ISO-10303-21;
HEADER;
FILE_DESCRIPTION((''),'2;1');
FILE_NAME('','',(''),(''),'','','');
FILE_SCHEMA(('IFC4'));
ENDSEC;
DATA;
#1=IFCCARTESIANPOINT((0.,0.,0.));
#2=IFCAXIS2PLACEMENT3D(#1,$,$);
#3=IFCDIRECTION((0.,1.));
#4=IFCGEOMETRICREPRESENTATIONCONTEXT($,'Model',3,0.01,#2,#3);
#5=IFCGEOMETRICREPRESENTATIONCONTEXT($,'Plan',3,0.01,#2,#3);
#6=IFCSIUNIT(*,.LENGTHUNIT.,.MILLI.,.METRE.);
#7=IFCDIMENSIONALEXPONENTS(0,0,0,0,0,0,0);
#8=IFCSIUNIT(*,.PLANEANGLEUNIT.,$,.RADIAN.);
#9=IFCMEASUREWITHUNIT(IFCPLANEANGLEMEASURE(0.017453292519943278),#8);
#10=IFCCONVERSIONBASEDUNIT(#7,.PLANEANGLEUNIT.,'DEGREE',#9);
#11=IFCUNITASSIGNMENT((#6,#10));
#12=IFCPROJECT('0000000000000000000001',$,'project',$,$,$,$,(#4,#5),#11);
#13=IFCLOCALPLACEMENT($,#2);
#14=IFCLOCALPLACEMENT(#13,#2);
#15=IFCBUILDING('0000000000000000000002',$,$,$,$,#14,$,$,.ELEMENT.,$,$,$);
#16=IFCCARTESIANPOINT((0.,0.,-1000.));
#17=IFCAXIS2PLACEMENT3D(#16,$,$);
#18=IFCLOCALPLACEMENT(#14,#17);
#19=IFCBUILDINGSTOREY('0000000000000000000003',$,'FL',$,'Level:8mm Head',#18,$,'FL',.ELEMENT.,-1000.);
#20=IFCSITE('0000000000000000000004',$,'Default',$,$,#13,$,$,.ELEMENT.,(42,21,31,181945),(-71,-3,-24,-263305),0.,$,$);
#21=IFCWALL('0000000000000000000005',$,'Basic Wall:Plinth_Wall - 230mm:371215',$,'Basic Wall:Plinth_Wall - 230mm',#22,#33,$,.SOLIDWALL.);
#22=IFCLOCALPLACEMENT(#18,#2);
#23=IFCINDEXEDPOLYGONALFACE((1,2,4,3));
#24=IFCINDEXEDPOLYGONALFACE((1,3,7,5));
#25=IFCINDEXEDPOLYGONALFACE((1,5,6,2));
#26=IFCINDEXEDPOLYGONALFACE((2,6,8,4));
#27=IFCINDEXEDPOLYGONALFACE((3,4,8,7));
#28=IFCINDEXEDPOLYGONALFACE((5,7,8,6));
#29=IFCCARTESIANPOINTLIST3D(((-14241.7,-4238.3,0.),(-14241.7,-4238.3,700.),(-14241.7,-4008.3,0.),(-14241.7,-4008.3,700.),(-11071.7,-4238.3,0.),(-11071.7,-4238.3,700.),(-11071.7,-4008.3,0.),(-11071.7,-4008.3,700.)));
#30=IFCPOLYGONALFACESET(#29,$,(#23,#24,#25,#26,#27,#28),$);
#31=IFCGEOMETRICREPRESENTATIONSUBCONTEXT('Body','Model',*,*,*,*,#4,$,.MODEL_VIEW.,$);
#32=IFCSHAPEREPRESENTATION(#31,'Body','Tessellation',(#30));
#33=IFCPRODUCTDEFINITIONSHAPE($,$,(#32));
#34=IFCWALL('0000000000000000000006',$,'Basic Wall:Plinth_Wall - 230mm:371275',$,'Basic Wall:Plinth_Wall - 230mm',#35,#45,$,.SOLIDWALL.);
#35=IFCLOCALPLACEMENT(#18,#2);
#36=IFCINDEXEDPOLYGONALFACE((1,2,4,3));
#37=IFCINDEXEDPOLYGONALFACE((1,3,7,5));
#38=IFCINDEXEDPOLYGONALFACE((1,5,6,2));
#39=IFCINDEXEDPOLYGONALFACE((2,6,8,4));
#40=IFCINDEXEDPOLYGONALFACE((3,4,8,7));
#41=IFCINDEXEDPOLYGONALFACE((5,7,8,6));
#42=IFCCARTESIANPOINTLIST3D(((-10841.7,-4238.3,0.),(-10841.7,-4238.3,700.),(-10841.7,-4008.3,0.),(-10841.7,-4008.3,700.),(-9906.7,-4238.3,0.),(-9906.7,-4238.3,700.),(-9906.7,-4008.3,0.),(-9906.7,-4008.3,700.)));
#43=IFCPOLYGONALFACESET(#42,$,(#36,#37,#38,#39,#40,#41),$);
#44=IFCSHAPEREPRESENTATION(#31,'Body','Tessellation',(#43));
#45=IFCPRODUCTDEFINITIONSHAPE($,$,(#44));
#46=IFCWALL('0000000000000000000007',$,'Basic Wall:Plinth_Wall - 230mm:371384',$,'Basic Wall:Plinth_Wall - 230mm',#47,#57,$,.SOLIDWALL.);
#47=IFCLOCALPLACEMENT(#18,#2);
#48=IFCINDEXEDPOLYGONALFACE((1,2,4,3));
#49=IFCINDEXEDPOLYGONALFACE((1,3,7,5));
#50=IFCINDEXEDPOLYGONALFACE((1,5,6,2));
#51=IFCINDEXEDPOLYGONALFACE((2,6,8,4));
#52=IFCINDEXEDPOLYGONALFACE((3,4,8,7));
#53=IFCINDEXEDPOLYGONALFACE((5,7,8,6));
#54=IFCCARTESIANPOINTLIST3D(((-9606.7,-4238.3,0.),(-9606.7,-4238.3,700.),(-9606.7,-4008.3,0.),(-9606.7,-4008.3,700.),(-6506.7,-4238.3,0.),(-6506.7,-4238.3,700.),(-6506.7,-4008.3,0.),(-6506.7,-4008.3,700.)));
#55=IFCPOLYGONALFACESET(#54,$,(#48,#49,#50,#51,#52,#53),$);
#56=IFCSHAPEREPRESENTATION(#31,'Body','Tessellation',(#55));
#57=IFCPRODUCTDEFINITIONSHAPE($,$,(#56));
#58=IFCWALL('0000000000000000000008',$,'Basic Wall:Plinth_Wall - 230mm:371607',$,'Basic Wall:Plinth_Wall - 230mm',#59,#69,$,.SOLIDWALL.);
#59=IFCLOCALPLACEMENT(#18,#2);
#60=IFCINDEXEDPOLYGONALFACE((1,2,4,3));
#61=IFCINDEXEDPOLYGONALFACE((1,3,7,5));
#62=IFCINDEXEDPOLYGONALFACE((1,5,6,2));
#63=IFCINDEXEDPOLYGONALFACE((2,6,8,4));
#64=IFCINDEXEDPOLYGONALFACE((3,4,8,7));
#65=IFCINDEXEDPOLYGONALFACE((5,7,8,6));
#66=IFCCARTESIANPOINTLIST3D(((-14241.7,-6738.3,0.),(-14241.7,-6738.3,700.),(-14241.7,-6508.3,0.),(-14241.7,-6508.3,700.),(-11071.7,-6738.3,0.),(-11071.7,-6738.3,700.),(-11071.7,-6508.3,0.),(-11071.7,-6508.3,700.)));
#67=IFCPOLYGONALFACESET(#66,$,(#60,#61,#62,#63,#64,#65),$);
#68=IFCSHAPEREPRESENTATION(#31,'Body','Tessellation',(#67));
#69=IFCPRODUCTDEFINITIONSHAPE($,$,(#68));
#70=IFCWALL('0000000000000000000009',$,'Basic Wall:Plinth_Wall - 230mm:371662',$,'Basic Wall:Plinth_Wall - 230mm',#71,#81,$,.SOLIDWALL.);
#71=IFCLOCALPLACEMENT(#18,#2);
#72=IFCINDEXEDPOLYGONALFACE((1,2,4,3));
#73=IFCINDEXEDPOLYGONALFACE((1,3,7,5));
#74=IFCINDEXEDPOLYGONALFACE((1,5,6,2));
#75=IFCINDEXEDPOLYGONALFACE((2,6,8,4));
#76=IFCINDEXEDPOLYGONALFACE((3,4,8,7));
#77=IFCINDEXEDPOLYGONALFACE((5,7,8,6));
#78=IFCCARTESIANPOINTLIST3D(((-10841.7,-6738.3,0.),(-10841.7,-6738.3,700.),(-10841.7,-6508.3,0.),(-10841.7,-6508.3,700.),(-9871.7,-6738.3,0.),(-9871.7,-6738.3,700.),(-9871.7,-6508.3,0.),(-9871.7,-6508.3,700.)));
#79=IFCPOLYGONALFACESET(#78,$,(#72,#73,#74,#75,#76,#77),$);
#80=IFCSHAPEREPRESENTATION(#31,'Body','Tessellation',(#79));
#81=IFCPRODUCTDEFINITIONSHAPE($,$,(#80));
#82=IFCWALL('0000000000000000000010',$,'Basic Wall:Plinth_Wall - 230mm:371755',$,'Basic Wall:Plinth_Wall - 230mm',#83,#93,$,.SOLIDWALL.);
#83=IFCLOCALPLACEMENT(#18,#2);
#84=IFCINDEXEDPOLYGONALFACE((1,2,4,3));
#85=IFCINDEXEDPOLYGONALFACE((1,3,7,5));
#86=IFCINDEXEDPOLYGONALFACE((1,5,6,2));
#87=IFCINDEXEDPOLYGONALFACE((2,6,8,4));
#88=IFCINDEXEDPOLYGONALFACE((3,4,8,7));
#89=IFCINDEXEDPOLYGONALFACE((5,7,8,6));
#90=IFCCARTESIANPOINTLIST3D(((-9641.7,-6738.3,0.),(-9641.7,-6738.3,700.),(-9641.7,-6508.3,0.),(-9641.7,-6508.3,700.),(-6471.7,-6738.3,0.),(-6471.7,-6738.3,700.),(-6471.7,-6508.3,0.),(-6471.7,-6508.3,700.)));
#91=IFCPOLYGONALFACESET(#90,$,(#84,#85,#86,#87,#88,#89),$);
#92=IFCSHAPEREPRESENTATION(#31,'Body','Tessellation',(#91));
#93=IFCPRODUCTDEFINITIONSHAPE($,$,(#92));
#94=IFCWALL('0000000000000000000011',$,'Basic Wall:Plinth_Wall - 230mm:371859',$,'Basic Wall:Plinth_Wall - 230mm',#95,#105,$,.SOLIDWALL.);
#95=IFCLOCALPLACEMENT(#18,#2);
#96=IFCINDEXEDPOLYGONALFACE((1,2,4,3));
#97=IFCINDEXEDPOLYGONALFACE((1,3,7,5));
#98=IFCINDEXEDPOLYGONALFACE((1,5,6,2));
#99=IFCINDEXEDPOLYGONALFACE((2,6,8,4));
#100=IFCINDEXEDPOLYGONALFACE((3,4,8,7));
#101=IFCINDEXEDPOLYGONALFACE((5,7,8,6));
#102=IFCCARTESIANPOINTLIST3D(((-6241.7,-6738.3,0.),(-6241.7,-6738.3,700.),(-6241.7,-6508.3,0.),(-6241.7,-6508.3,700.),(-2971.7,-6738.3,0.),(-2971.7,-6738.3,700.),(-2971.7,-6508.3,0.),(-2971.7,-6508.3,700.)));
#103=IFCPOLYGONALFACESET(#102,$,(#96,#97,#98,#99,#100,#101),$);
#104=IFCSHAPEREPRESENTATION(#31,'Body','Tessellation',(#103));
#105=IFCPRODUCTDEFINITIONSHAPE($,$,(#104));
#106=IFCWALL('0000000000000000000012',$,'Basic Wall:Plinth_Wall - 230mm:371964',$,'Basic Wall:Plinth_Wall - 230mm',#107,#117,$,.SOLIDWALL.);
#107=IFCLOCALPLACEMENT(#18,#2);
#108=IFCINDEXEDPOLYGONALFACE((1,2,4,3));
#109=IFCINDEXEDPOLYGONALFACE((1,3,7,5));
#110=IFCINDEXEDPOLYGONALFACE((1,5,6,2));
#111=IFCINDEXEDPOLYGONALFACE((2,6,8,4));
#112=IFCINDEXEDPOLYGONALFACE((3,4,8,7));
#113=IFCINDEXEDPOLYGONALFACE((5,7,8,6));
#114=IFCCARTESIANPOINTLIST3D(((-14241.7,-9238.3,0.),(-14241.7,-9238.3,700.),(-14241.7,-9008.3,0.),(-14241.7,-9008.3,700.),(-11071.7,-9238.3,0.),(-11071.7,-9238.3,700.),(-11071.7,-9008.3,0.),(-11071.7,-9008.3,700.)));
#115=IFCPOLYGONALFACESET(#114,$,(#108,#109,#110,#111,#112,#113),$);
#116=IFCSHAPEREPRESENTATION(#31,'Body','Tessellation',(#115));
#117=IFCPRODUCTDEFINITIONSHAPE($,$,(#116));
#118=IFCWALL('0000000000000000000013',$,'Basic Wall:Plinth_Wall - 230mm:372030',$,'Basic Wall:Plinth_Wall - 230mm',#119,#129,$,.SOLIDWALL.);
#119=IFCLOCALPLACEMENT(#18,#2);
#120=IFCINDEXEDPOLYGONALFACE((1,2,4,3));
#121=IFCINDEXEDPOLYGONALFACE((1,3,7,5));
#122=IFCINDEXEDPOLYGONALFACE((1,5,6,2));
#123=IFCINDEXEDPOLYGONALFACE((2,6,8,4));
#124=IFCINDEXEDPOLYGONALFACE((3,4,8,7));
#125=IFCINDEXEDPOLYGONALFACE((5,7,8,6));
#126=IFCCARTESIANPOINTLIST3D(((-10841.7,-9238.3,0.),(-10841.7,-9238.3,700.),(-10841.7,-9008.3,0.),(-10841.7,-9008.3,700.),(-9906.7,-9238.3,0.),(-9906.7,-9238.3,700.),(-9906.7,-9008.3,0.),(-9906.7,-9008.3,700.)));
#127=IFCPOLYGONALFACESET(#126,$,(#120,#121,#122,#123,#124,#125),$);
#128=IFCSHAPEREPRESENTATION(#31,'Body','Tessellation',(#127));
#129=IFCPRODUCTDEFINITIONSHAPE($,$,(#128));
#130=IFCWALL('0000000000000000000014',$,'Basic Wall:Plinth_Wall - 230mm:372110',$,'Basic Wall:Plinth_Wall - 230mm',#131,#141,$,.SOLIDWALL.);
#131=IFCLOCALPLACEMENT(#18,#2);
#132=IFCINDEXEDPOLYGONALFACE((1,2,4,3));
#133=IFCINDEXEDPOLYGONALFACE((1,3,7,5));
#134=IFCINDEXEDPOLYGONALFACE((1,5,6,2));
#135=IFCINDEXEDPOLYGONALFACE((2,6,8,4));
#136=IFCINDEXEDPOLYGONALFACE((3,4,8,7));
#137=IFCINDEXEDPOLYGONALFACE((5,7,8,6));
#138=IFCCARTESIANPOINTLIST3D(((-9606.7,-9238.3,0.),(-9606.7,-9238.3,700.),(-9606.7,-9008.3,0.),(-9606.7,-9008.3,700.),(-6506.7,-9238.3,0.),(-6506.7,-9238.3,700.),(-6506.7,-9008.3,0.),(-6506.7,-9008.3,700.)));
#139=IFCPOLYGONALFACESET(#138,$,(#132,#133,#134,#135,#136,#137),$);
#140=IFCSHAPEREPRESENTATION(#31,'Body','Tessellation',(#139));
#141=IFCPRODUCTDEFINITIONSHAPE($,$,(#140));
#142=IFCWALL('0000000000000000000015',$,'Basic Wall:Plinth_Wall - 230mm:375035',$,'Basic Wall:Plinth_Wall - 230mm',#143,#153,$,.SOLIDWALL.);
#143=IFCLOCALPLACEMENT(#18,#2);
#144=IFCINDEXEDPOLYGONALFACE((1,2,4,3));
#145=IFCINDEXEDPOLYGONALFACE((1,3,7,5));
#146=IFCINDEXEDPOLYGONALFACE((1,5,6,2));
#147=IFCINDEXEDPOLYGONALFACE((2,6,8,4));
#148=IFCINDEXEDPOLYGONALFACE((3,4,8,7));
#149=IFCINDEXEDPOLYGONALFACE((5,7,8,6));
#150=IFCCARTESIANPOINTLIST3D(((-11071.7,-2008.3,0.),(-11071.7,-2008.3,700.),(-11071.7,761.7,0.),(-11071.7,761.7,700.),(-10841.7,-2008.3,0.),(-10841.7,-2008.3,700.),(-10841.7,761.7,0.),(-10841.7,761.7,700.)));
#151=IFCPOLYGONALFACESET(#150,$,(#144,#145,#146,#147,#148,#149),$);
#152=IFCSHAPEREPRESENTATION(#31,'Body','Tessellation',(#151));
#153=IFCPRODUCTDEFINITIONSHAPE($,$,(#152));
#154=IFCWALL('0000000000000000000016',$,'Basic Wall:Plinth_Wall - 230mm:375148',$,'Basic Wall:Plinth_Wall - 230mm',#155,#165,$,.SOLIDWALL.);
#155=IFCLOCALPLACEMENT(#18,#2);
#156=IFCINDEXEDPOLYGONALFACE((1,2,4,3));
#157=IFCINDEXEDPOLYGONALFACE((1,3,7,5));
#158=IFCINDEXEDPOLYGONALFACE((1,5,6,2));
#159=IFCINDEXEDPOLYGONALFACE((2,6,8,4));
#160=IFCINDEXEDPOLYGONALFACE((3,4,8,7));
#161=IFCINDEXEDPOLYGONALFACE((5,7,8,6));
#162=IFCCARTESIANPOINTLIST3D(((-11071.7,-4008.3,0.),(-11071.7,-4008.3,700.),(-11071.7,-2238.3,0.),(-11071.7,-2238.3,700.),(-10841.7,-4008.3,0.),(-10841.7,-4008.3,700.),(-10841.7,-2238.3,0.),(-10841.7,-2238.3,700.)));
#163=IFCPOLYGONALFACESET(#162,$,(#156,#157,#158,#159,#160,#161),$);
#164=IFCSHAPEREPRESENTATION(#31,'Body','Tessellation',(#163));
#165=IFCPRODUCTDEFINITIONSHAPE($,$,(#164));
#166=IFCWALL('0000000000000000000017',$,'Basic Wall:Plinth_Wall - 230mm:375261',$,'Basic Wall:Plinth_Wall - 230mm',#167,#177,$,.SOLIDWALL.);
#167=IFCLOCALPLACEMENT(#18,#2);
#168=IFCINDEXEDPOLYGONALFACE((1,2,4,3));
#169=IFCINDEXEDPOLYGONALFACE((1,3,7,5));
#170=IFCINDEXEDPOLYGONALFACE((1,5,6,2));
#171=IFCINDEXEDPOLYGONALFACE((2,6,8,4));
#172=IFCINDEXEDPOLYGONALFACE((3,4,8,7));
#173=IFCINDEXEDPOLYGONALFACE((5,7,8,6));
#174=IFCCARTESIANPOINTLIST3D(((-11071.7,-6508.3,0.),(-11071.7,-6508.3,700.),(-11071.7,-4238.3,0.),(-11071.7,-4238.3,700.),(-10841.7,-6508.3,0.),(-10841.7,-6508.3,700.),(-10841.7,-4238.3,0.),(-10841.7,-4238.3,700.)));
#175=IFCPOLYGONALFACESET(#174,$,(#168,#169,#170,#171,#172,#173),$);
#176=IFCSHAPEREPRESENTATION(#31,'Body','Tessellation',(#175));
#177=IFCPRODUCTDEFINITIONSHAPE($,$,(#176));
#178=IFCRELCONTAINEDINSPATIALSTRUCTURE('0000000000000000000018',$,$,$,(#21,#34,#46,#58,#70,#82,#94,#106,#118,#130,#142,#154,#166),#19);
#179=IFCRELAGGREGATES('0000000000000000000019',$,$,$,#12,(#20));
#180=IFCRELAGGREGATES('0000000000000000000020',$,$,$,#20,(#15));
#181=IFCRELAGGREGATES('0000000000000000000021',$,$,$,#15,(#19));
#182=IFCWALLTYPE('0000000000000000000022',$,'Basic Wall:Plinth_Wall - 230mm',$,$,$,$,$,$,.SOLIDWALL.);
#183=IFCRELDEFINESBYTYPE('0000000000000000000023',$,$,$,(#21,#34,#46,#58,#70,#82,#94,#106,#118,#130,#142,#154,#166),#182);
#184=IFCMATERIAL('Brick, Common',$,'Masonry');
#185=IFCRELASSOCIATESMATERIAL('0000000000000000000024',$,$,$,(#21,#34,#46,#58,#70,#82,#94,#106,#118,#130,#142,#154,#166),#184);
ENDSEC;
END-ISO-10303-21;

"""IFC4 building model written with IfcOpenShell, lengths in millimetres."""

from ifc_helpers import new_model, entity, si_unit, converted_unit, direction, frame, origin, place, context, subcontext, project, spatial, indexed_curve, outline, extrude, material, type_object, element, save


model = new_model("IFC4")

# Units and contexts
model_context = context("Model", 3, precision=0.01, world=origin(), true_north=direction((0.0, 1.0)))
plan_context = context("Plan", 3, precision=0.01, world=origin(), true_north=direction((0.0, 1.0)))
body_context = subcontext(model_context, "Body", "Model", "MODEL_VIEW")
ifc_project = project(units=[si_unit("LENGTHUNIT", "METRE", prefix="MILLI"), converted_unit("PLANEANGLEUNIT", "DEGREE", entity("IfcPlaneAngleMeasure", 0.017453292519943278), si_unit("PLANEANGLEUNIT", "RADIAN"), dimensions=[0, 0, 0, 0, 0, 0, 0])], contexts=[model_context, plan_context])

# Site, building, storey
site_placement = place(None, origin())
site = spatial("IfcSite", under=ifc_project, at=site_placement, Name="Default", CompositionType="ELEMENT", RefLatitude=(42, 21, 31, 181945), RefLongitude=(-71, -3, -24, -263305), RefElevation=0.0)
building_placement = place(site_placement, origin())
building = spatial("IfcBuilding", under=site, at=building_placement, CompositionType="ELEMENT")
storey_placement = place(building_placement, frame((0.0, 0.0, -1000.0)))
storey = spatial("IfcBuildingStorey", under=building, at=storey_placement, Name="FL", ObjectType="Level:8mm Head", LongName="FL", CompositionType="ELEMENT", Elevation=-1000.0)

# Walls
ifc_material = material(Name="Brick, Common", Category="Masonry")
wall_type = type_object("IfcWallType", Name="Basic Wall:Plinth_Wall - 230mm", PredefinedType="SOLIDWALL")
wall_1_placement = place(storey_placement, frame((-14241.7, -4123.3, 0.0)))
element("IfcWall", 1, at=wall_1_placement, inside=storey, type_object=wall_type, material=ifc_material, Name="Basic Wall:Plinth_Wall - 230mm:371215", ObjectType="Basic Wall:Plinth_Wall - 230mm", PredefinedType="SOLIDWALL", context=body_context, shape_type="SweptSolid", body=[
    extrude(outline(indexed_curve([(3170.0, 115.0), (0.0, 115.0), (0.0, -115.0), (3170.0, -115.0), (3170.0, 115.0)], self_intersect=False)), origin(), (0.0, 0.0, 1.0), 700.0),
])
wall_2_placement = place(storey_placement, frame((-10841.7, -4123.3, 0.0)))
element("IfcWall", 2, at=wall_2_placement, inside=storey, type_object=wall_type, material=ifc_material, Name="Basic Wall:Plinth_Wall - 230mm:371275", ObjectType="Basic Wall:Plinth_Wall - 230mm", PredefinedType="SOLIDWALL", context=body_context, shape_type="SweptSolid", body=[
    extrude(outline(indexed_curve([(935.0, 115.0), (0.0, 115.0), (0.0, -115.0), (935.0, -115.0), (935.0, 115.0)], self_intersect=False)), origin(), (0.0, 0.0, 1.0), 700.0),
])
wall_3_placement = place(storey_placement, frame((-9606.7, -4123.3, 0.0)))
element("IfcWall", 3, at=wall_3_placement, inside=storey, type_object=wall_type, material=ifc_material, Name="Basic Wall:Plinth_Wall - 230mm:371384", ObjectType="Basic Wall:Plinth_Wall - 230mm", PredefinedType="SOLIDWALL", context=body_context, shape_type="SweptSolid", body=[
    extrude(outline(indexed_curve([(3100.0, 115.0), (0.0, 115.0), (0.0, -115.0), (3100.0, -115.0), (3100.0, 115.0)], self_intersect=False)), origin(), (0.0, 0.0, 1.0), 700.0),
])
wall_4_placement = place(storey_placement, frame((-14241.7, -6623.3, 0.0)))
element("IfcWall", 4, at=wall_4_placement, inside=storey, type_object=wall_type, material=ifc_material, Name="Basic Wall:Plinth_Wall - 230mm:371607", ObjectType="Basic Wall:Plinth_Wall - 230mm", PredefinedType="SOLIDWALL", context=body_context, shape_type="SweptSolid", body=[
    extrude(outline(indexed_curve([(3170.0, 115.0), (0.0, 115.0), (0.0, -115.0), (3170.0, -115.0), (3170.0, 115.0)], self_intersect=False)), origin(), (0.0, 0.0, 1.0), 700.0),
])
wall_5_placement = place(storey_placement, frame((-10841.7, -6623.3, 0.0)))
element("IfcWall", 5, at=wall_5_placement, inside=storey, type_object=wall_type, material=ifc_material, Name="Basic Wall:Plinth_Wall - 230mm:371662", ObjectType="Basic Wall:Plinth_Wall - 230mm", PredefinedType="SOLIDWALL", context=body_context, shape_type="SweptSolid", body=[
    extrude(outline(indexed_curve([(970.0, 115.0), (0.0, 115.0), (0.0, -115.0), (970.0, -115.0), (970.0, 115.0)], self_intersect=False)), origin(), (0.0, 0.0, 1.0), 700.0),
])
wall_6_placement = place(storey_placement, frame((-9641.7, -6623.3, 0.0)))
element("IfcWall", 6, at=wall_6_placement, inside=storey, type_object=wall_type, material=ifc_material, Name="Basic Wall:Plinth_Wall - 230mm:371755", ObjectType="Basic Wall:Plinth_Wall - 230mm", PredefinedType="SOLIDWALL", context=body_context, shape_type="SweptSolid", body=[
    extrude(outline(indexed_curve([(3170.0, 115.0), (0.0, 115.0), (0.0, -115.0), (3170.0, -115.0), (3170.0, 115.0)], self_intersect=False)), origin(), (0.0, 0.0, 1.0), 700.0),
])
wall_7_placement = place(storey_placement, frame((-6241.7, -6623.3, 0.0)))
element("IfcWall", 7, at=wall_7_placement, inside=storey, type_object=wall_type, material=ifc_material, Name="Basic Wall:Plinth_Wall - 230mm:371859", ObjectType="Basic Wall:Plinth_Wall - 230mm", PredefinedType="SOLIDWALL", context=body_context, shape_type="SweptSolid", body=[
    extrude(outline(indexed_curve([(3270.0, 115.0), (0.0, 115.0), (0.0, -115.0), (3270.0, -115.0), (3270.0, 115.0)], self_intersect=False)), origin(), (0.0, 0.0, 1.0), 700.0),
])
wall_8_placement = place(storey_placement, frame((-14241.7, -9123.3, 0.0)))
element("IfcWall", 8, at=wall_8_placement, inside=storey, type_object=wall_type, material=ifc_material, Name="Basic Wall:Plinth_Wall - 230mm:371964", ObjectType="Basic Wall:Plinth_Wall - 230mm", PredefinedType="SOLIDWALL", context=body_context, shape_type="SweptSolid", body=[
    extrude(outline(indexed_curve([(3170.0, 115.0), (0.0, 115.0), (0.0, -115.0), (3170.0, -115.0), (3170.0, 115.0)], self_intersect=False)), origin(), (0.0, 0.0, 1.0), 700.0),
])
wall_9_placement = place(storey_placement, frame((-10841.7, -9123.3, 0.0)))
element("IfcWall", 9, at=wall_9_placement, inside=storey, type_object=wall_type, material=ifc_material, Name="Basic Wall:Plinth_Wall - 230mm:372030", ObjectType="Basic Wall:Plinth_Wall - 230mm", PredefinedType="SOLIDWALL", context=body_context, shape_type="SweptSolid", body=[
    extrude(outline(indexed_curve([(935.0, 115.0), (0.0, 115.0), (0.0, -115.0), (935.0, -115.0), (935.0, 115.0)], self_intersect=False)), origin(), (0.0, 0.0, 1.0), 700.0),
])
wall_10_placement = place(storey_placement, frame((-9606.7, -9123.3, 0.0)))
element("IfcWall", 10, at=wall_10_placement, inside=storey, type_object=wall_type, material=ifc_material, Name="Basic Wall:Plinth_Wall - 230mm:372110", ObjectType="Basic Wall:Plinth_Wall - 230mm", PredefinedType="SOLIDWALL", context=body_context, shape_type="SweptSolid", body=[
    extrude(outline(indexed_curve([(3100.0, 115.0), (0.0, 115.0), (0.0, -115.0), (3100.0, -115.0), (3100.0, 115.0)], self_intersect=False)), origin(), (0.0, 0.0, 1.0), 700.0),
])
wall_11_placement = place(storey_placement, frame((-10956.7, 761.7, 0.0), z_axis=(0.0, 0.0, 1.0), x_axis=(0.0, -1.0, 0.0)))
element("IfcWall", 11, at=wall_11_placement, inside=storey, type_object=wall_type, material=ifc_material, Name="Basic Wall:Plinth_Wall - 230mm:375035", ObjectType="Basic Wall:Plinth_Wall - 230mm", PredefinedType="SOLIDWALL", context=body_context, shape_type="SweptSolid", body=[
    extrude(outline(indexed_curve([(2770.0, 115.0), (0.0, 115.0), (0.0, -115.0), (2770.0, -115.0), (2770.0, 115.0)], self_intersect=False)), origin(), (0.0, 0.0, 1.0), 700.0),
])
wall_12_placement = place(storey_placement, frame((-10956.7, -2238.3, 0.0), z_axis=(0.0, 0.0, 1.0), x_axis=(0.0, -1.0, 0.0)))
element("IfcWall", 12, at=wall_12_placement, inside=storey, type_object=wall_type, material=ifc_material, Name="Basic Wall:Plinth_Wall - 230mm:375148", ObjectType="Basic Wall:Plinth_Wall - 230mm", PredefinedType="SOLIDWALL", context=body_context, shape_type="SweptSolid", body=[
    extrude(outline(indexed_curve([(1770.0, 115.0), (0.0, 115.0), (0.0, -115.0), (1770.0, -115.0), (1770.0, 115.0)], self_intersect=False)), origin(), (0.0, 0.0, 1.0), 700.0),
])
wall_13_placement = place(storey_placement, frame((-10956.7, -4238.3, 0.0), z_axis=(0.0, 0.0, 1.0), x_axis=(0.0, -1.0, 0.0)))
element("IfcWall", 13, at=wall_13_placement, inside=storey, type_object=wall_type, material=ifc_material, Name="Basic Wall:Plinth_Wall - 230mm:375261", ObjectType="Basic Wall:Plinth_Wall - 230mm", PredefinedType="SOLIDWALL", context=body_context, shape_type="SweptSolid", body=[
    extrude(outline(indexed_curve([(2270.0, 115.0), (0.0, 115.0), (0.0, -115.0), (2270.0, -115.0), (2270.0, 115.0)], self_intersect=False)), origin(), (0.0, 0.0, 1.0), 700.0),
])

save(model, "model.ifc")
